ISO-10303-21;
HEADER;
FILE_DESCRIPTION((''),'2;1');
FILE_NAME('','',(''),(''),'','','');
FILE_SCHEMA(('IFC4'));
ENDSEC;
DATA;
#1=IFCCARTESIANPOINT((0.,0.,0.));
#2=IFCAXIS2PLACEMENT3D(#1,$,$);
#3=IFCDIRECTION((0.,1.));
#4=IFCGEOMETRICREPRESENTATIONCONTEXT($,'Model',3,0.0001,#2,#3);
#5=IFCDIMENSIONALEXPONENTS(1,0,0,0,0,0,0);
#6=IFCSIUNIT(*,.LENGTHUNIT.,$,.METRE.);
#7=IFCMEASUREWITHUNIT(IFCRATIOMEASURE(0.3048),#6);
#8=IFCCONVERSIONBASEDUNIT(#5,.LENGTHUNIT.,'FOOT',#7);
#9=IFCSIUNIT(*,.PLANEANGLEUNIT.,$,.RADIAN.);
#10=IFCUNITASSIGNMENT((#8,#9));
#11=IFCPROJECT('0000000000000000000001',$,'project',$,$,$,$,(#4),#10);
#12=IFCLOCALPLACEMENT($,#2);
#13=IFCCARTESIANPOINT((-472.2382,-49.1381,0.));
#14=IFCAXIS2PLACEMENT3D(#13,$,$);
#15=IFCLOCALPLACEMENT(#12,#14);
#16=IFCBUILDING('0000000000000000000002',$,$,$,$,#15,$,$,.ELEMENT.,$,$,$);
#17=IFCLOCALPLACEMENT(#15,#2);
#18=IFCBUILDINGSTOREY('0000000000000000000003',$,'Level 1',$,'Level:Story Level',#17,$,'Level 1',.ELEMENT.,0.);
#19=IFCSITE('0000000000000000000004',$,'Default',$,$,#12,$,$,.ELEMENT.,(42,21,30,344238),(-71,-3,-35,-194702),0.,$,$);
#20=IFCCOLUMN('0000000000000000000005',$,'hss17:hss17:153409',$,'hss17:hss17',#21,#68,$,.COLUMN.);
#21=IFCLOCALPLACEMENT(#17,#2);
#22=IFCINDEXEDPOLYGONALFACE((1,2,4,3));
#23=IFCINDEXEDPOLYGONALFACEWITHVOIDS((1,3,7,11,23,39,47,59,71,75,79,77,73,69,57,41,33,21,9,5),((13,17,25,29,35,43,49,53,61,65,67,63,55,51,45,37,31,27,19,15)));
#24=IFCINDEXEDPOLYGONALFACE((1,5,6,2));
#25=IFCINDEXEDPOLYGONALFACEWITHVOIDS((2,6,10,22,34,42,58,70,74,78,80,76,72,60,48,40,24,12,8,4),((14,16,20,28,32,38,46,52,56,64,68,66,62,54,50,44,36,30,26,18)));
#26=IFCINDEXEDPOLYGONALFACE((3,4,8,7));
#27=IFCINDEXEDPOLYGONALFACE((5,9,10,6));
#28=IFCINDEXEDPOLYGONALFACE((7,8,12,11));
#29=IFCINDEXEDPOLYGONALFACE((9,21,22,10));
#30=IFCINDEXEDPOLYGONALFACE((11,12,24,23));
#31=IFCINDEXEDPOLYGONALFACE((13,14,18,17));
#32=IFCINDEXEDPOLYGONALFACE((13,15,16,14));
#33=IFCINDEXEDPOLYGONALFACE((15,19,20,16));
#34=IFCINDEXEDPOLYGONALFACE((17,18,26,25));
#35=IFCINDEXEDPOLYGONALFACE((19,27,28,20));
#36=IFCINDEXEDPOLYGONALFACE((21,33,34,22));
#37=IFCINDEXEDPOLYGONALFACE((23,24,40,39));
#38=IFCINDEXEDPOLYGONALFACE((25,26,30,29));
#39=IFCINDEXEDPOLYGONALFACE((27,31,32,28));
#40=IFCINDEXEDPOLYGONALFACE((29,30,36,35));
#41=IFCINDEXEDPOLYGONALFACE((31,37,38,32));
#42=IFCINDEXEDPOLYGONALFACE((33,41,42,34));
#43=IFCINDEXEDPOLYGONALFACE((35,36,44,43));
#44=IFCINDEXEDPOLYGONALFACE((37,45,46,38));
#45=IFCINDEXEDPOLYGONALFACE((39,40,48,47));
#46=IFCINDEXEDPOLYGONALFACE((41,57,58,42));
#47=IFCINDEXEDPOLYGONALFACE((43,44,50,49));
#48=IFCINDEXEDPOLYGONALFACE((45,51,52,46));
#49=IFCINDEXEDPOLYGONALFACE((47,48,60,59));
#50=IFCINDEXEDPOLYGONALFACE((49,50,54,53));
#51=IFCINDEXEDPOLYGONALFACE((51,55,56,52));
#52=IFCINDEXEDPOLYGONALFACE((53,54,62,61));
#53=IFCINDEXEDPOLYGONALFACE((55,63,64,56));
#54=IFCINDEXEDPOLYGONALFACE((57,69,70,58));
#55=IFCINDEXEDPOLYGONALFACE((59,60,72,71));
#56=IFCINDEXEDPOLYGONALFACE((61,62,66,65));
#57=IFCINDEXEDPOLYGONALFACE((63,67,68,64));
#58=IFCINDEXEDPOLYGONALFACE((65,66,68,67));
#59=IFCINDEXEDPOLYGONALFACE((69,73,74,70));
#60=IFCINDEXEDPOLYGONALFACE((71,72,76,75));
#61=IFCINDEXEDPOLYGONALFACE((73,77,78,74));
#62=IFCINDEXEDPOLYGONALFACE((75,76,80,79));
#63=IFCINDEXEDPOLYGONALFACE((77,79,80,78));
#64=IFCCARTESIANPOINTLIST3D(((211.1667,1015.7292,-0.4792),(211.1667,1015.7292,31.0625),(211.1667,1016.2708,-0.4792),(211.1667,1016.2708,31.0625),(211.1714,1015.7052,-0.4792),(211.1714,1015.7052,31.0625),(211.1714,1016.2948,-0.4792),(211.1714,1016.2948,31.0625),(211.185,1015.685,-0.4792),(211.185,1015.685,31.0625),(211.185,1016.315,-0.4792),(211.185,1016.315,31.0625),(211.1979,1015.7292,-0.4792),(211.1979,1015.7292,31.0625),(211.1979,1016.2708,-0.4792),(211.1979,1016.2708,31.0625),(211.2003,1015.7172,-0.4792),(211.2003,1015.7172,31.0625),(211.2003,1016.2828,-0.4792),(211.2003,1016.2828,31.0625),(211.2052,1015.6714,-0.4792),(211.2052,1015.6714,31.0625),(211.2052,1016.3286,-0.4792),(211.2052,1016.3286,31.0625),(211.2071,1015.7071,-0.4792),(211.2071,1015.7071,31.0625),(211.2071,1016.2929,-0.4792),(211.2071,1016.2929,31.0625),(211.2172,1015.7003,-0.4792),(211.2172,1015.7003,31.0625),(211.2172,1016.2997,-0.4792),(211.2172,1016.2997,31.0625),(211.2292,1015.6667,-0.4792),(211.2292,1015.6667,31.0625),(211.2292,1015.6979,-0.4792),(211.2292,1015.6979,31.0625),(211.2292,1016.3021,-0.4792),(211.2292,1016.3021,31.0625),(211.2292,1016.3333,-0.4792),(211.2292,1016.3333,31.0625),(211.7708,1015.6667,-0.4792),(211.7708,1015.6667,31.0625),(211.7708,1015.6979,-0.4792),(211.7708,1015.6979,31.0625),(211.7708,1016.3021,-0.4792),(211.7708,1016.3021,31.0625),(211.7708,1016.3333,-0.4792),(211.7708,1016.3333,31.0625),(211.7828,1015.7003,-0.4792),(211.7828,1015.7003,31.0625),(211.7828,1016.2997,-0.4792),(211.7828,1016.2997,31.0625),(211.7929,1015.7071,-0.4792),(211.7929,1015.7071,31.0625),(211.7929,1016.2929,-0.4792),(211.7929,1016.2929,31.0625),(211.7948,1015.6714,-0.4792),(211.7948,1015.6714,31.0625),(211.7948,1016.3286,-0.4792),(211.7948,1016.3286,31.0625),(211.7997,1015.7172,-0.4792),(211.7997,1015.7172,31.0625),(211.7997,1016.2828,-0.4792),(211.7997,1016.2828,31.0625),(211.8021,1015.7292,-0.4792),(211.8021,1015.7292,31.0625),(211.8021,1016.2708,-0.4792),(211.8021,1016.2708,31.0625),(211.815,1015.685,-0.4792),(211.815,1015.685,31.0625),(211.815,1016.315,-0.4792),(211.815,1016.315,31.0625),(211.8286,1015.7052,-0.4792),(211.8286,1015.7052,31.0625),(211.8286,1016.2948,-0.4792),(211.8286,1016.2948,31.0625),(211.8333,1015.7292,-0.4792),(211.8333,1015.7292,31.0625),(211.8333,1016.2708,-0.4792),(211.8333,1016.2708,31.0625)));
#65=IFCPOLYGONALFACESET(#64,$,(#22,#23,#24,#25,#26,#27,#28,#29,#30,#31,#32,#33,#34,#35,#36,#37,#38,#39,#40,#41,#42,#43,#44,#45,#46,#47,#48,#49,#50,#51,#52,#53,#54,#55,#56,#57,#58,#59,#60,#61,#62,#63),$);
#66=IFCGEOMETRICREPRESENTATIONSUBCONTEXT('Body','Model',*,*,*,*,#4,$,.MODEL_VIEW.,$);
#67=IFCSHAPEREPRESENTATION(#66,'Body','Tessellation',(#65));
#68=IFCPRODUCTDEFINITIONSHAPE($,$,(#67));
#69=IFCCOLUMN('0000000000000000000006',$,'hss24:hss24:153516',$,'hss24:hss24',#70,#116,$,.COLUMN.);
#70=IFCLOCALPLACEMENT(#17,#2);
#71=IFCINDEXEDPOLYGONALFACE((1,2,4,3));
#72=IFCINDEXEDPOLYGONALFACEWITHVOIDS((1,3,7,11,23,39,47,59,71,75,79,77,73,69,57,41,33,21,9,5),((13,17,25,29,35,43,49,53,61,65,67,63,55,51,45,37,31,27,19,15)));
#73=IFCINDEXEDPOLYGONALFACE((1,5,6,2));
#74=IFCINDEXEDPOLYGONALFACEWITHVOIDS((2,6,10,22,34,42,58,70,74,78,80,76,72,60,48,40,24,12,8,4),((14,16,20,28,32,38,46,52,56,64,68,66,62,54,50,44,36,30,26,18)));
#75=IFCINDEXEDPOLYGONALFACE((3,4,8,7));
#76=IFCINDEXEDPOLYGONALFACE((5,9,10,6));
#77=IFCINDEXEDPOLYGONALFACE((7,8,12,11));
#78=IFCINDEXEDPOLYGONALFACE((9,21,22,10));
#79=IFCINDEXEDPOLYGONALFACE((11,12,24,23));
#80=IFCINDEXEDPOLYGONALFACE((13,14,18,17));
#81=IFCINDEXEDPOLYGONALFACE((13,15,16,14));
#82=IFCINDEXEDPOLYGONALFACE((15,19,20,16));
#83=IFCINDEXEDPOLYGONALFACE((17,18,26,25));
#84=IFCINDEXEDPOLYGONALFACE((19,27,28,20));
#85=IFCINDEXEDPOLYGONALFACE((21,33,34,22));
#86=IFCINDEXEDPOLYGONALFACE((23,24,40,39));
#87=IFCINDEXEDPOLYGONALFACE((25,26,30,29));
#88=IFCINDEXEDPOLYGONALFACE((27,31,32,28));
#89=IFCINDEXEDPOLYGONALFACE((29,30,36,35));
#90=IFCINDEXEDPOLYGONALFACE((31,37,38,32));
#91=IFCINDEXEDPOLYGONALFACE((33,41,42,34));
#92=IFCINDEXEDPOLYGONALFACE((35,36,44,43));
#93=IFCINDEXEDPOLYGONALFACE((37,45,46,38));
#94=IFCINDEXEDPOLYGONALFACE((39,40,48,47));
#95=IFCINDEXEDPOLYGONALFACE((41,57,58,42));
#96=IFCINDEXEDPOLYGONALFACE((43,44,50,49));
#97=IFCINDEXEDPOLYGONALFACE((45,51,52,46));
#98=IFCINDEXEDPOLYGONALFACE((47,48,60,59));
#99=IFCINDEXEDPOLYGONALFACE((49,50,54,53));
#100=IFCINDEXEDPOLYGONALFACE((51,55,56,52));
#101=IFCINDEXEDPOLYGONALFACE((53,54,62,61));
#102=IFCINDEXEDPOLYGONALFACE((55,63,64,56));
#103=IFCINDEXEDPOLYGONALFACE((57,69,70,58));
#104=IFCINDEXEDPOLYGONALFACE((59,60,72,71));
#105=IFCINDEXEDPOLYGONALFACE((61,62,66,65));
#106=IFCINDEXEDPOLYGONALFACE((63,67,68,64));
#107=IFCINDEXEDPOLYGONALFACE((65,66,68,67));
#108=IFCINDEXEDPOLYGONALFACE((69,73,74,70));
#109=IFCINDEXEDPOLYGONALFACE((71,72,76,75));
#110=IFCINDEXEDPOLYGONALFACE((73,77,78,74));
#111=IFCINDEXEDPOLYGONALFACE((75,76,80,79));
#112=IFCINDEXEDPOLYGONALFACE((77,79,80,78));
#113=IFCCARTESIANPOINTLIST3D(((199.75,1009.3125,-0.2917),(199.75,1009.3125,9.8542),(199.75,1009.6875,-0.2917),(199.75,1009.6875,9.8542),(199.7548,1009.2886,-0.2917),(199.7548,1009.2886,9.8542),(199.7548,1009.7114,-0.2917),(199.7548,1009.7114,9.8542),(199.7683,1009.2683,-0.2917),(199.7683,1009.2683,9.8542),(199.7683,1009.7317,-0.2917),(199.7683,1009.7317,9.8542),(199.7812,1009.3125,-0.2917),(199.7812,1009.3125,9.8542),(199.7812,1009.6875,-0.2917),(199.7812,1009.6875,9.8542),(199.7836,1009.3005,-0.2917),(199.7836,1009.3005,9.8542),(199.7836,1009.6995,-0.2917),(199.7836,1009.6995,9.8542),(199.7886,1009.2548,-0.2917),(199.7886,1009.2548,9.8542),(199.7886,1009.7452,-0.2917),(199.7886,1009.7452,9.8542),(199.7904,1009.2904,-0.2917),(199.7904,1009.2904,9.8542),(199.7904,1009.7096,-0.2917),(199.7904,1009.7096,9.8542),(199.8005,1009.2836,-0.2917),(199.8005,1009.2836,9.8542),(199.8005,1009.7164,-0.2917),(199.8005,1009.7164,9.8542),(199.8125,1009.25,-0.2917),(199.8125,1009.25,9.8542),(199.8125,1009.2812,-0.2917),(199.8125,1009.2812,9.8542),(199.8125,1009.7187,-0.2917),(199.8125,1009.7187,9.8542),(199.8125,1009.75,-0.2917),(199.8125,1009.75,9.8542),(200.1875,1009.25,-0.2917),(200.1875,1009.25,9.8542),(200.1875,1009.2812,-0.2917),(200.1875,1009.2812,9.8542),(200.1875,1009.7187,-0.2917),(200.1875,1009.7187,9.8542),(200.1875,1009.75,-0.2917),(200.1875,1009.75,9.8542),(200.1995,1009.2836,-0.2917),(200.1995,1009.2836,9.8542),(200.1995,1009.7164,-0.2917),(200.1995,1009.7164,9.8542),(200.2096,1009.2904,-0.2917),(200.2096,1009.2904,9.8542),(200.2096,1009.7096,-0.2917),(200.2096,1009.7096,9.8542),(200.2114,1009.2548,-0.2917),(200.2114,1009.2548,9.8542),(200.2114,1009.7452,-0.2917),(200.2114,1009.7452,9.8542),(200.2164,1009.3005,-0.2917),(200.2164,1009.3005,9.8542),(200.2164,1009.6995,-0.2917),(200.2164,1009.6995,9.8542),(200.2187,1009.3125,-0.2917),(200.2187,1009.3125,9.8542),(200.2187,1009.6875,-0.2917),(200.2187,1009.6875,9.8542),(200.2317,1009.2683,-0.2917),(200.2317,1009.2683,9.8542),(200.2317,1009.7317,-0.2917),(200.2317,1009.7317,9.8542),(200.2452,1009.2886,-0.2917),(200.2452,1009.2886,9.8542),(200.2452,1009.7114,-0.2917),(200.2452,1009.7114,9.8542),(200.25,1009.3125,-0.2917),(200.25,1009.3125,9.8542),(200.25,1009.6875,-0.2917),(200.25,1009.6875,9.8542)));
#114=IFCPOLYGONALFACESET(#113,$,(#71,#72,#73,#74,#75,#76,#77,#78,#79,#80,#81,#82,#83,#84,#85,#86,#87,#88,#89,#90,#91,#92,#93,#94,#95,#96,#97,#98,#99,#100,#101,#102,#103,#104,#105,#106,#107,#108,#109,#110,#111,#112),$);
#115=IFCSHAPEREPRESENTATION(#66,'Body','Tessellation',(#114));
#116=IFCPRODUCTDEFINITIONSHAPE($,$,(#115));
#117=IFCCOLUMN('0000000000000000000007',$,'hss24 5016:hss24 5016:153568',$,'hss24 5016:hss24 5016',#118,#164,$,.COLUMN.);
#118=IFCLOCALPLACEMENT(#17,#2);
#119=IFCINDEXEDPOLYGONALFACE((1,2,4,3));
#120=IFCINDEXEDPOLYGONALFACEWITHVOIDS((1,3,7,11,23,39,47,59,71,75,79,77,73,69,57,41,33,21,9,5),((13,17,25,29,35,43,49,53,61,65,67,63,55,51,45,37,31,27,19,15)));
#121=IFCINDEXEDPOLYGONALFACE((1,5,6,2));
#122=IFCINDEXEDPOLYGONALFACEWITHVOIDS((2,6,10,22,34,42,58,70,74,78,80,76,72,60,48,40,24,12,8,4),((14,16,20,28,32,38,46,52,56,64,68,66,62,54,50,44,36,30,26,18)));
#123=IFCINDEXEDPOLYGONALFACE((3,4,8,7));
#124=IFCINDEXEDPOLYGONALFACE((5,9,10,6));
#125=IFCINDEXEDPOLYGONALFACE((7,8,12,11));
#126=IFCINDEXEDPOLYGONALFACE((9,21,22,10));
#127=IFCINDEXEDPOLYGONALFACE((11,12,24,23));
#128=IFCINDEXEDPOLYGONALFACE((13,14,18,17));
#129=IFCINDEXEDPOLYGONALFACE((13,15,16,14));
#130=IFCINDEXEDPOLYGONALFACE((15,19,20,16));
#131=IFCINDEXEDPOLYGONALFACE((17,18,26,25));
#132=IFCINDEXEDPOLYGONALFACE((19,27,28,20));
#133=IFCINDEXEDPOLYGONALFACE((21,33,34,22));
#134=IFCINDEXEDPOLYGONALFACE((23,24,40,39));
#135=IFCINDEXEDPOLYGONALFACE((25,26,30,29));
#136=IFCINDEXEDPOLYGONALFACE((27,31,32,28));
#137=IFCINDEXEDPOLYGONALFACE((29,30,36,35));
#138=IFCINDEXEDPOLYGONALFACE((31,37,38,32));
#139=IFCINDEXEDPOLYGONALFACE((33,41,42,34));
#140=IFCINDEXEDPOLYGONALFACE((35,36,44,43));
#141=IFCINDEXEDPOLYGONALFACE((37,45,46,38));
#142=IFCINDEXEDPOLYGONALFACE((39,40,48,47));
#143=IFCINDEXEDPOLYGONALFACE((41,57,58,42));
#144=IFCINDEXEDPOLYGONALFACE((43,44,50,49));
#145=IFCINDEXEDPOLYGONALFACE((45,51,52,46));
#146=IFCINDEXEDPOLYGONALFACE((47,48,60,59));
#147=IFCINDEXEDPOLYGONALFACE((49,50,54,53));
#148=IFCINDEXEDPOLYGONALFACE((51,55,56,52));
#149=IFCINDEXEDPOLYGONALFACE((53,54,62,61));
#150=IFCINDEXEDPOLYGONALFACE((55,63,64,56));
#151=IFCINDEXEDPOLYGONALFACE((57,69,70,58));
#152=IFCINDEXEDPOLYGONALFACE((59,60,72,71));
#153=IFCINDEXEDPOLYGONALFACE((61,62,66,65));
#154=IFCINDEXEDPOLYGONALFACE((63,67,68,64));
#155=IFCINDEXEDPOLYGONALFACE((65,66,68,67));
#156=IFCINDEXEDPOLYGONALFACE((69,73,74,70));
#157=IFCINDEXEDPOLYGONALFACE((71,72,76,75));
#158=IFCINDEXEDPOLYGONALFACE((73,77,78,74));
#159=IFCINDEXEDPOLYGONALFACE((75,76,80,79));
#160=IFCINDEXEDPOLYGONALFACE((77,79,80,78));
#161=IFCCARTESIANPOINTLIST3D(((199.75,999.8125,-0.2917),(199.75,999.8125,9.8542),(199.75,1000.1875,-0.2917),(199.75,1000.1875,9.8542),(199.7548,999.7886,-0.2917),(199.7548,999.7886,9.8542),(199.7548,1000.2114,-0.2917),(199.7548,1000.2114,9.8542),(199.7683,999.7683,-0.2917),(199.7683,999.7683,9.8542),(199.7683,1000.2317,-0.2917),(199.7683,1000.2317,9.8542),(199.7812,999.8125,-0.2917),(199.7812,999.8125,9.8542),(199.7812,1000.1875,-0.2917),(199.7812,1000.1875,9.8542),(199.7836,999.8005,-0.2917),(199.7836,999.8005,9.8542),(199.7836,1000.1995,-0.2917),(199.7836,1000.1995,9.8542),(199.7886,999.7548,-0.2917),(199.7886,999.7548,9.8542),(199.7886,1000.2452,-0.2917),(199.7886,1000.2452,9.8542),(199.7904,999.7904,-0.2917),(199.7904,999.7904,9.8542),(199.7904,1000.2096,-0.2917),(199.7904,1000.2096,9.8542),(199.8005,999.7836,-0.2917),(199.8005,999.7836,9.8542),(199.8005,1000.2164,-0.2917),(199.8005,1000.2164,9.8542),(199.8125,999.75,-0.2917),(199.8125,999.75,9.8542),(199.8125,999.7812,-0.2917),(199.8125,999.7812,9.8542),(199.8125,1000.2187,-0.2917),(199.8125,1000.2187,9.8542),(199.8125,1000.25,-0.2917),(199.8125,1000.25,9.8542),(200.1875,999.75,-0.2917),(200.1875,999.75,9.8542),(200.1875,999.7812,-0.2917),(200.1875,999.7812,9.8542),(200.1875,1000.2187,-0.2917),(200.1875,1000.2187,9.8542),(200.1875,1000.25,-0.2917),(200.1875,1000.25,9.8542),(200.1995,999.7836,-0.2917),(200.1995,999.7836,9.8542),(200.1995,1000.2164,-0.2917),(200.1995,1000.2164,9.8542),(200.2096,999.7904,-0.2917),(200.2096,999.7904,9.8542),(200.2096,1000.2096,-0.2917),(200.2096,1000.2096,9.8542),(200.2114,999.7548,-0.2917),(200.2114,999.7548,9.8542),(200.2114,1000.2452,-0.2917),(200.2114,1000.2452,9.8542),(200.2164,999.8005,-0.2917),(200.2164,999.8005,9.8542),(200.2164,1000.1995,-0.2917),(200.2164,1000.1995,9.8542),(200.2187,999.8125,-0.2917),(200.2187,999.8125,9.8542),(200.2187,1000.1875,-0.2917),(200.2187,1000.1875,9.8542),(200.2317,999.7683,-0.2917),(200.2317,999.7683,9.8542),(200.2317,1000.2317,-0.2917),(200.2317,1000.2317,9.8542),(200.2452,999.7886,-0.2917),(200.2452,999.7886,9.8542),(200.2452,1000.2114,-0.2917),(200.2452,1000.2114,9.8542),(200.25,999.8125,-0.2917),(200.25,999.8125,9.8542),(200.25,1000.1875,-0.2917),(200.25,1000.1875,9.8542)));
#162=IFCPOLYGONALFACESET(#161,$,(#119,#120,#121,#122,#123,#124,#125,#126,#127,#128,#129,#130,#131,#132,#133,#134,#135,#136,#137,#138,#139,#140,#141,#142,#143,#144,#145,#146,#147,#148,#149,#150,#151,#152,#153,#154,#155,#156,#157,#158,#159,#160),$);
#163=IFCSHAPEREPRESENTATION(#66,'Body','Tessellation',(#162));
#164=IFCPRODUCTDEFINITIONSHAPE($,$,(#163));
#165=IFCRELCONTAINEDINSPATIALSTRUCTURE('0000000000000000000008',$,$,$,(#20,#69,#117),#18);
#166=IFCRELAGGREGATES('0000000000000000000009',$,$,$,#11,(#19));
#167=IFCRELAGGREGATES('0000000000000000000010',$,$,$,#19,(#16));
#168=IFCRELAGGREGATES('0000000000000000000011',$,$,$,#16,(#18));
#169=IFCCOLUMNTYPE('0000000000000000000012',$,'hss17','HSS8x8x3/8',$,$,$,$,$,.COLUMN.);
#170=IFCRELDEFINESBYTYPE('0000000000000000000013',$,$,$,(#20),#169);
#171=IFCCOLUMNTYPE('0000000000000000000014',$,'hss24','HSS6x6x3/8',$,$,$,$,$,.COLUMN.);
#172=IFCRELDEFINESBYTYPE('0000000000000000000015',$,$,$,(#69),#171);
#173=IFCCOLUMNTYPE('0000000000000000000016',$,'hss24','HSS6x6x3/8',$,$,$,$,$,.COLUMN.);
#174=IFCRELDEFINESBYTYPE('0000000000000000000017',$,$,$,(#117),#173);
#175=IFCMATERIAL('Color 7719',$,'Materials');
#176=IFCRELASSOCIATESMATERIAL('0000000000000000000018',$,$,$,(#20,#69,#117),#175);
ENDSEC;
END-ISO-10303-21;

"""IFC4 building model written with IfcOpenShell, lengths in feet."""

from ifc_helpers import new_model, entity, si_unit, converted_unit, direction, frame, origin, place, context, subcontext, project, spatial, polyline, outline, extrude, boolean, source, transform, mapped, material, type_object, type_shapes, element, save


model = new_model("IFC4")

# Units and contexts
model_context = context("Model", 3, precision=0.0001, world=origin(), true_north=direction((0.0, 1.0)))
body_context = subcontext(model_context, "Body", "Model", "MODEL_VIEW")
ifc_project = project(units=[converted_unit("LENGTHUNIT", "FOOT", entity("IfcRatioMeasure", 0.3048), si_unit("LENGTHUNIT", "METRE"), dimensions=[1, 0, 0, 0, 0, 0, 0]), si_unit("PLANEANGLEUNIT", "RADIAN")], contexts=[model_context])

# Site, building, storey
site_placement = place(None, origin())
site = spatial("IfcSite", under=ifc_project, at=site_placement, Name="Default", CompositionType="ELEMENT", RefLatitude=(42, 21, 30, 344238), RefLongitude=(-71, -3, -35, -194702), RefElevation=0.0)
building_placement = place(site_placement, frame((-472.2382, -49.1381, 0.0)))
building = spatial("IfcBuilding", under=site, at=building_placement, CompositionType="ELEMENT")
storey_placement = place(building_placement, origin())
storey = spatial("IfcBuildingStorey", under=building, at=storey_placement, Name="Level 1", ObjectType="Level:Story Level", LongName="Level 1", CompositionType="ELEMENT", Elevation=0.0)

# Columns
ifc_material_1 = material(Name="Color 7719", Category="Materials")
column_type_1 = type_object("IfcColumnType", Name="hss17", Description="HSS8x8x3/8", PredefinedType="COLUMN")
shared_shape_1 = source(origin(), body_context, "Body", "CSG", [
    boolean("DIFFERENCE", extrude(outline(polyline([(-0.2708, -0.3333), (0.2708, -0.3333), (0.2948, -0.3286), (0.315, -0.315), (0.3286, -0.2948), (0.3333, -0.2708), (0.3333, 0.2708), (0.3286, 0.2948), (0.315, 0.315), (0.2948, 0.3286), (0.2708, 0.3333), (-0.2708, 0.3333), (-0.2948, 0.3286), (-0.315, 0.315), (-0.3286, 0.2948), (-0.3333, 0.2708), (-0.3333, -0.2708), (-0.3286, -0.2948), (-0.315, -0.315), (-0.2948, -0.3286), (-0.2708, -0.3333)])), frame((211.5, 1016.0, -0.4792), z_axis=(0.0, 0.0, 1.0), x_axis=(0.0, -1.0, 0.0)), (0.0, 0.0, 1.0), 31.5417), extrude(outline(polyline([(-0.2708, -0.3021), (0.2708, -0.3021), (0.2828, -0.2997), (0.2929, -0.2929), (0.2997, -0.2828), (0.3021, -0.2708), (0.3021, 0.2708), (0.2997, 0.2828), (0.2929, 0.2929), (0.2828, 0.2997), (0.2708, 0.3021), (-0.2708, 0.3021), (-0.2828, 0.2997), (-0.2929, 0.2929), (-0.2997, 0.2828), (-0.3021, 0.2708), (-0.3021, -0.2708), (-0.2997, -0.2828), (-0.2929, -0.2929), (-0.2828, -0.2997), (-0.2708, -0.3021)])), frame((211.5, 1016.0, 31.0625), z_axis=(0.0, 0.0, -1.0), x_axis=(0.0, -1.0, 0.0)), (0.0, 0.0, 1.0), 31.5417)),
])
type_shapes(column_type_1, [shared_shape_1])
column_1_placement = place(building_placement, origin())
element("IfcColumn", 1, at=column_1_placement, inside=storey, type_object=column_type_1, material=ifc_material_1, Name="hss17:hss17:153409", ObjectType="hss17:hss17", PredefinedType="COLUMN", context=body_context, shape_type="MappedRepresentation", body=[
    mapped(shared_shape_1, transform((0.0, 0.0, 0.0), scale=1.0)),
])
column_type_2 = type_object("IfcColumnType", Name="hss24", Description="HSS6x6x3/8", PredefinedType="COLUMN")
shared_shape_2 = source(origin(), body_context, "Body", "CSG", [
    boolean("DIFFERENCE", extrude(outline(polyline([(-0.1875, -0.25), (0.1875, -0.25), (0.2114, -0.2452), (0.2317, -0.2317), (0.2452, -0.2114), (0.25, -0.1875), (0.25, 0.1875), (0.2452, 0.2114), (0.2317, 0.2317), (0.2114, 0.2452), (0.1875, 0.25), (-0.1875, 0.25), (-0.2114, 0.2452), (-0.2317, 0.2317), (-0.2452, 0.2114), (-0.25, 0.1875), (-0.25, -0.1875), (-0.2452, -0.2114), (-0.2317, -0.2317), (-0.2114, -0.2452), (-0.1875, -0.25)])), frame((200.0, 1009.5, -0.2917), z_axis=(0.0, 0.0, 1.0), x_axis=(0.0, -1.0, 0.0)), (0.0, 0.0, 1.0), 10.1458), extrude(outline(polyline([(-0.1875, -0.2187), (0.1875, -0.2187), (0.1995, -0.2164), (0.2096, -0.2096), (0.2164, -0.1995), (0.2188, -0.1875), (0.2188, 0.1875), (0.2164, 0.1995), (0.2096, 0.2096), (0.1995, 0.2164), (0.1875, 0.2188), (-0.1875, 0.2188), (-0.1995, 0.2164), (-0.2096, 0.2096), (-0.2164, 0.1995), (-0.2188, 0.1875), (-0.2188, -0.1875), (-0.2164, -0.1995), (-0.2096, -0.2096), (-0.1995, -0.2164), (-0.1875, -0.2187)])), frame((200.0, 1009.5, 9.8542), z_axis=(0.0, 0.0, -1.0), x_axis=(0.0, -1.0, 0.0)), (0.0, 0.0, 1.0), 10.1458)),
])
type_shapes(column_type_2, [shared_shape_2])
column_2_placement = place(building_placement, origin())
element("IfcColumn", 2, at=column_2_placement, inside=storey, type_object=column_type_2, material=ifc_material_1, Name="hss24:hss24:153516", ObjectType="hss24:hss24", PredefinedType="COLUMN", context=body_context, shape_type="MappedRepresentation", body=[
    mapped(shared_shape_2, transform((0.0, 0.0, 0.0), scale=1.0)),
])
column_type_3 = type_object("IfcColumnType", Name="hss24", Description="HSS6x6x3/8", PredefinedType="COLUMN")
shared_shape_3 = source(origin(), body_context, "Body", "CSG", [
    boolean("DIFFERENCE", extrude(outline(polyline([(-0.1875, -0.25), (0.1875, -0.25), (0.2114, -0.2452), (0.2317, -0.2317), (0.2452, -0.2114), (0.25, -0.1875), (0.25, 0.1875), (0.2452, 0.2114), (0.2317, 0.2317), (0.2114, 0.2452), (0.1875, 0.25), (-0.1875, 0.25), (-0.2114, 0.2452), (-0.2317, 0.2317), (-0.2452, 0.2114), (-0.25, 0.1875), (-0.25, -0.1875), (-0.2452, -0.2114), (-0.2317, -0.2317), (-0.2114, -0.2452), (-0.1875, -0.25)])), frame((200.0, 1000.0, -0.2917), z_axis=(0.0, 0.0, 1.0), x_axis=(0.0, -1.0, 0.0)), (0.0, 0.0, 1.0), 10.1458), extrude(outline(polyline([(-0.1875, -0.2187), (0.1875, -0.2187), (0.1995, -0.2164), (0.2096, -0.2096), (0.2164, -0.1995), (0.2188, -0.1875), (0.2188, 0.1875), (0.2164, 0.1995), (0.2096, 0.2096), (0.1995, 0.2164), (0.1875, 0.2188), (-0.1875, 0.2188), (-0.1995, 0.2164), (-0.2096, 0.2096), (-0.2164, 0.1995), (-0.2188, 0.1875), (-0.2188, -0.1875), (-0.2164, -0.1995), (-0.2096, -0.2096), (-0.1995, -0.2164), (-0.1875, -0.2187)])), frame((200.0, 1000.0, 9.8542), z_axis=(0.0, 0.0, -1.0), x_axis=(0.0, -1.0, 0.0)), (0.0, 0.0, 1.0), 10.1458)),
])
type_shapes(column_type_3, [shared_shape_3])
column_3_placement = place(building_placement, origin())
element("IfcColumn", 3, at=column_3_placement, inside=storey, type_object=column_type_3, material=ifc_material_1, Name="hss24 5016:hss24 5016:153568", ObjectType="hss24 5016:hss24 5016", PredefinedType="COLUMN", context=body_context, shape_type="MappedRepresentation", body=[
    mapped(shared_shape_3, transform((0.0, 0.0, 0.0), scale=1.0)),
])

save(model, "model.ifc")
